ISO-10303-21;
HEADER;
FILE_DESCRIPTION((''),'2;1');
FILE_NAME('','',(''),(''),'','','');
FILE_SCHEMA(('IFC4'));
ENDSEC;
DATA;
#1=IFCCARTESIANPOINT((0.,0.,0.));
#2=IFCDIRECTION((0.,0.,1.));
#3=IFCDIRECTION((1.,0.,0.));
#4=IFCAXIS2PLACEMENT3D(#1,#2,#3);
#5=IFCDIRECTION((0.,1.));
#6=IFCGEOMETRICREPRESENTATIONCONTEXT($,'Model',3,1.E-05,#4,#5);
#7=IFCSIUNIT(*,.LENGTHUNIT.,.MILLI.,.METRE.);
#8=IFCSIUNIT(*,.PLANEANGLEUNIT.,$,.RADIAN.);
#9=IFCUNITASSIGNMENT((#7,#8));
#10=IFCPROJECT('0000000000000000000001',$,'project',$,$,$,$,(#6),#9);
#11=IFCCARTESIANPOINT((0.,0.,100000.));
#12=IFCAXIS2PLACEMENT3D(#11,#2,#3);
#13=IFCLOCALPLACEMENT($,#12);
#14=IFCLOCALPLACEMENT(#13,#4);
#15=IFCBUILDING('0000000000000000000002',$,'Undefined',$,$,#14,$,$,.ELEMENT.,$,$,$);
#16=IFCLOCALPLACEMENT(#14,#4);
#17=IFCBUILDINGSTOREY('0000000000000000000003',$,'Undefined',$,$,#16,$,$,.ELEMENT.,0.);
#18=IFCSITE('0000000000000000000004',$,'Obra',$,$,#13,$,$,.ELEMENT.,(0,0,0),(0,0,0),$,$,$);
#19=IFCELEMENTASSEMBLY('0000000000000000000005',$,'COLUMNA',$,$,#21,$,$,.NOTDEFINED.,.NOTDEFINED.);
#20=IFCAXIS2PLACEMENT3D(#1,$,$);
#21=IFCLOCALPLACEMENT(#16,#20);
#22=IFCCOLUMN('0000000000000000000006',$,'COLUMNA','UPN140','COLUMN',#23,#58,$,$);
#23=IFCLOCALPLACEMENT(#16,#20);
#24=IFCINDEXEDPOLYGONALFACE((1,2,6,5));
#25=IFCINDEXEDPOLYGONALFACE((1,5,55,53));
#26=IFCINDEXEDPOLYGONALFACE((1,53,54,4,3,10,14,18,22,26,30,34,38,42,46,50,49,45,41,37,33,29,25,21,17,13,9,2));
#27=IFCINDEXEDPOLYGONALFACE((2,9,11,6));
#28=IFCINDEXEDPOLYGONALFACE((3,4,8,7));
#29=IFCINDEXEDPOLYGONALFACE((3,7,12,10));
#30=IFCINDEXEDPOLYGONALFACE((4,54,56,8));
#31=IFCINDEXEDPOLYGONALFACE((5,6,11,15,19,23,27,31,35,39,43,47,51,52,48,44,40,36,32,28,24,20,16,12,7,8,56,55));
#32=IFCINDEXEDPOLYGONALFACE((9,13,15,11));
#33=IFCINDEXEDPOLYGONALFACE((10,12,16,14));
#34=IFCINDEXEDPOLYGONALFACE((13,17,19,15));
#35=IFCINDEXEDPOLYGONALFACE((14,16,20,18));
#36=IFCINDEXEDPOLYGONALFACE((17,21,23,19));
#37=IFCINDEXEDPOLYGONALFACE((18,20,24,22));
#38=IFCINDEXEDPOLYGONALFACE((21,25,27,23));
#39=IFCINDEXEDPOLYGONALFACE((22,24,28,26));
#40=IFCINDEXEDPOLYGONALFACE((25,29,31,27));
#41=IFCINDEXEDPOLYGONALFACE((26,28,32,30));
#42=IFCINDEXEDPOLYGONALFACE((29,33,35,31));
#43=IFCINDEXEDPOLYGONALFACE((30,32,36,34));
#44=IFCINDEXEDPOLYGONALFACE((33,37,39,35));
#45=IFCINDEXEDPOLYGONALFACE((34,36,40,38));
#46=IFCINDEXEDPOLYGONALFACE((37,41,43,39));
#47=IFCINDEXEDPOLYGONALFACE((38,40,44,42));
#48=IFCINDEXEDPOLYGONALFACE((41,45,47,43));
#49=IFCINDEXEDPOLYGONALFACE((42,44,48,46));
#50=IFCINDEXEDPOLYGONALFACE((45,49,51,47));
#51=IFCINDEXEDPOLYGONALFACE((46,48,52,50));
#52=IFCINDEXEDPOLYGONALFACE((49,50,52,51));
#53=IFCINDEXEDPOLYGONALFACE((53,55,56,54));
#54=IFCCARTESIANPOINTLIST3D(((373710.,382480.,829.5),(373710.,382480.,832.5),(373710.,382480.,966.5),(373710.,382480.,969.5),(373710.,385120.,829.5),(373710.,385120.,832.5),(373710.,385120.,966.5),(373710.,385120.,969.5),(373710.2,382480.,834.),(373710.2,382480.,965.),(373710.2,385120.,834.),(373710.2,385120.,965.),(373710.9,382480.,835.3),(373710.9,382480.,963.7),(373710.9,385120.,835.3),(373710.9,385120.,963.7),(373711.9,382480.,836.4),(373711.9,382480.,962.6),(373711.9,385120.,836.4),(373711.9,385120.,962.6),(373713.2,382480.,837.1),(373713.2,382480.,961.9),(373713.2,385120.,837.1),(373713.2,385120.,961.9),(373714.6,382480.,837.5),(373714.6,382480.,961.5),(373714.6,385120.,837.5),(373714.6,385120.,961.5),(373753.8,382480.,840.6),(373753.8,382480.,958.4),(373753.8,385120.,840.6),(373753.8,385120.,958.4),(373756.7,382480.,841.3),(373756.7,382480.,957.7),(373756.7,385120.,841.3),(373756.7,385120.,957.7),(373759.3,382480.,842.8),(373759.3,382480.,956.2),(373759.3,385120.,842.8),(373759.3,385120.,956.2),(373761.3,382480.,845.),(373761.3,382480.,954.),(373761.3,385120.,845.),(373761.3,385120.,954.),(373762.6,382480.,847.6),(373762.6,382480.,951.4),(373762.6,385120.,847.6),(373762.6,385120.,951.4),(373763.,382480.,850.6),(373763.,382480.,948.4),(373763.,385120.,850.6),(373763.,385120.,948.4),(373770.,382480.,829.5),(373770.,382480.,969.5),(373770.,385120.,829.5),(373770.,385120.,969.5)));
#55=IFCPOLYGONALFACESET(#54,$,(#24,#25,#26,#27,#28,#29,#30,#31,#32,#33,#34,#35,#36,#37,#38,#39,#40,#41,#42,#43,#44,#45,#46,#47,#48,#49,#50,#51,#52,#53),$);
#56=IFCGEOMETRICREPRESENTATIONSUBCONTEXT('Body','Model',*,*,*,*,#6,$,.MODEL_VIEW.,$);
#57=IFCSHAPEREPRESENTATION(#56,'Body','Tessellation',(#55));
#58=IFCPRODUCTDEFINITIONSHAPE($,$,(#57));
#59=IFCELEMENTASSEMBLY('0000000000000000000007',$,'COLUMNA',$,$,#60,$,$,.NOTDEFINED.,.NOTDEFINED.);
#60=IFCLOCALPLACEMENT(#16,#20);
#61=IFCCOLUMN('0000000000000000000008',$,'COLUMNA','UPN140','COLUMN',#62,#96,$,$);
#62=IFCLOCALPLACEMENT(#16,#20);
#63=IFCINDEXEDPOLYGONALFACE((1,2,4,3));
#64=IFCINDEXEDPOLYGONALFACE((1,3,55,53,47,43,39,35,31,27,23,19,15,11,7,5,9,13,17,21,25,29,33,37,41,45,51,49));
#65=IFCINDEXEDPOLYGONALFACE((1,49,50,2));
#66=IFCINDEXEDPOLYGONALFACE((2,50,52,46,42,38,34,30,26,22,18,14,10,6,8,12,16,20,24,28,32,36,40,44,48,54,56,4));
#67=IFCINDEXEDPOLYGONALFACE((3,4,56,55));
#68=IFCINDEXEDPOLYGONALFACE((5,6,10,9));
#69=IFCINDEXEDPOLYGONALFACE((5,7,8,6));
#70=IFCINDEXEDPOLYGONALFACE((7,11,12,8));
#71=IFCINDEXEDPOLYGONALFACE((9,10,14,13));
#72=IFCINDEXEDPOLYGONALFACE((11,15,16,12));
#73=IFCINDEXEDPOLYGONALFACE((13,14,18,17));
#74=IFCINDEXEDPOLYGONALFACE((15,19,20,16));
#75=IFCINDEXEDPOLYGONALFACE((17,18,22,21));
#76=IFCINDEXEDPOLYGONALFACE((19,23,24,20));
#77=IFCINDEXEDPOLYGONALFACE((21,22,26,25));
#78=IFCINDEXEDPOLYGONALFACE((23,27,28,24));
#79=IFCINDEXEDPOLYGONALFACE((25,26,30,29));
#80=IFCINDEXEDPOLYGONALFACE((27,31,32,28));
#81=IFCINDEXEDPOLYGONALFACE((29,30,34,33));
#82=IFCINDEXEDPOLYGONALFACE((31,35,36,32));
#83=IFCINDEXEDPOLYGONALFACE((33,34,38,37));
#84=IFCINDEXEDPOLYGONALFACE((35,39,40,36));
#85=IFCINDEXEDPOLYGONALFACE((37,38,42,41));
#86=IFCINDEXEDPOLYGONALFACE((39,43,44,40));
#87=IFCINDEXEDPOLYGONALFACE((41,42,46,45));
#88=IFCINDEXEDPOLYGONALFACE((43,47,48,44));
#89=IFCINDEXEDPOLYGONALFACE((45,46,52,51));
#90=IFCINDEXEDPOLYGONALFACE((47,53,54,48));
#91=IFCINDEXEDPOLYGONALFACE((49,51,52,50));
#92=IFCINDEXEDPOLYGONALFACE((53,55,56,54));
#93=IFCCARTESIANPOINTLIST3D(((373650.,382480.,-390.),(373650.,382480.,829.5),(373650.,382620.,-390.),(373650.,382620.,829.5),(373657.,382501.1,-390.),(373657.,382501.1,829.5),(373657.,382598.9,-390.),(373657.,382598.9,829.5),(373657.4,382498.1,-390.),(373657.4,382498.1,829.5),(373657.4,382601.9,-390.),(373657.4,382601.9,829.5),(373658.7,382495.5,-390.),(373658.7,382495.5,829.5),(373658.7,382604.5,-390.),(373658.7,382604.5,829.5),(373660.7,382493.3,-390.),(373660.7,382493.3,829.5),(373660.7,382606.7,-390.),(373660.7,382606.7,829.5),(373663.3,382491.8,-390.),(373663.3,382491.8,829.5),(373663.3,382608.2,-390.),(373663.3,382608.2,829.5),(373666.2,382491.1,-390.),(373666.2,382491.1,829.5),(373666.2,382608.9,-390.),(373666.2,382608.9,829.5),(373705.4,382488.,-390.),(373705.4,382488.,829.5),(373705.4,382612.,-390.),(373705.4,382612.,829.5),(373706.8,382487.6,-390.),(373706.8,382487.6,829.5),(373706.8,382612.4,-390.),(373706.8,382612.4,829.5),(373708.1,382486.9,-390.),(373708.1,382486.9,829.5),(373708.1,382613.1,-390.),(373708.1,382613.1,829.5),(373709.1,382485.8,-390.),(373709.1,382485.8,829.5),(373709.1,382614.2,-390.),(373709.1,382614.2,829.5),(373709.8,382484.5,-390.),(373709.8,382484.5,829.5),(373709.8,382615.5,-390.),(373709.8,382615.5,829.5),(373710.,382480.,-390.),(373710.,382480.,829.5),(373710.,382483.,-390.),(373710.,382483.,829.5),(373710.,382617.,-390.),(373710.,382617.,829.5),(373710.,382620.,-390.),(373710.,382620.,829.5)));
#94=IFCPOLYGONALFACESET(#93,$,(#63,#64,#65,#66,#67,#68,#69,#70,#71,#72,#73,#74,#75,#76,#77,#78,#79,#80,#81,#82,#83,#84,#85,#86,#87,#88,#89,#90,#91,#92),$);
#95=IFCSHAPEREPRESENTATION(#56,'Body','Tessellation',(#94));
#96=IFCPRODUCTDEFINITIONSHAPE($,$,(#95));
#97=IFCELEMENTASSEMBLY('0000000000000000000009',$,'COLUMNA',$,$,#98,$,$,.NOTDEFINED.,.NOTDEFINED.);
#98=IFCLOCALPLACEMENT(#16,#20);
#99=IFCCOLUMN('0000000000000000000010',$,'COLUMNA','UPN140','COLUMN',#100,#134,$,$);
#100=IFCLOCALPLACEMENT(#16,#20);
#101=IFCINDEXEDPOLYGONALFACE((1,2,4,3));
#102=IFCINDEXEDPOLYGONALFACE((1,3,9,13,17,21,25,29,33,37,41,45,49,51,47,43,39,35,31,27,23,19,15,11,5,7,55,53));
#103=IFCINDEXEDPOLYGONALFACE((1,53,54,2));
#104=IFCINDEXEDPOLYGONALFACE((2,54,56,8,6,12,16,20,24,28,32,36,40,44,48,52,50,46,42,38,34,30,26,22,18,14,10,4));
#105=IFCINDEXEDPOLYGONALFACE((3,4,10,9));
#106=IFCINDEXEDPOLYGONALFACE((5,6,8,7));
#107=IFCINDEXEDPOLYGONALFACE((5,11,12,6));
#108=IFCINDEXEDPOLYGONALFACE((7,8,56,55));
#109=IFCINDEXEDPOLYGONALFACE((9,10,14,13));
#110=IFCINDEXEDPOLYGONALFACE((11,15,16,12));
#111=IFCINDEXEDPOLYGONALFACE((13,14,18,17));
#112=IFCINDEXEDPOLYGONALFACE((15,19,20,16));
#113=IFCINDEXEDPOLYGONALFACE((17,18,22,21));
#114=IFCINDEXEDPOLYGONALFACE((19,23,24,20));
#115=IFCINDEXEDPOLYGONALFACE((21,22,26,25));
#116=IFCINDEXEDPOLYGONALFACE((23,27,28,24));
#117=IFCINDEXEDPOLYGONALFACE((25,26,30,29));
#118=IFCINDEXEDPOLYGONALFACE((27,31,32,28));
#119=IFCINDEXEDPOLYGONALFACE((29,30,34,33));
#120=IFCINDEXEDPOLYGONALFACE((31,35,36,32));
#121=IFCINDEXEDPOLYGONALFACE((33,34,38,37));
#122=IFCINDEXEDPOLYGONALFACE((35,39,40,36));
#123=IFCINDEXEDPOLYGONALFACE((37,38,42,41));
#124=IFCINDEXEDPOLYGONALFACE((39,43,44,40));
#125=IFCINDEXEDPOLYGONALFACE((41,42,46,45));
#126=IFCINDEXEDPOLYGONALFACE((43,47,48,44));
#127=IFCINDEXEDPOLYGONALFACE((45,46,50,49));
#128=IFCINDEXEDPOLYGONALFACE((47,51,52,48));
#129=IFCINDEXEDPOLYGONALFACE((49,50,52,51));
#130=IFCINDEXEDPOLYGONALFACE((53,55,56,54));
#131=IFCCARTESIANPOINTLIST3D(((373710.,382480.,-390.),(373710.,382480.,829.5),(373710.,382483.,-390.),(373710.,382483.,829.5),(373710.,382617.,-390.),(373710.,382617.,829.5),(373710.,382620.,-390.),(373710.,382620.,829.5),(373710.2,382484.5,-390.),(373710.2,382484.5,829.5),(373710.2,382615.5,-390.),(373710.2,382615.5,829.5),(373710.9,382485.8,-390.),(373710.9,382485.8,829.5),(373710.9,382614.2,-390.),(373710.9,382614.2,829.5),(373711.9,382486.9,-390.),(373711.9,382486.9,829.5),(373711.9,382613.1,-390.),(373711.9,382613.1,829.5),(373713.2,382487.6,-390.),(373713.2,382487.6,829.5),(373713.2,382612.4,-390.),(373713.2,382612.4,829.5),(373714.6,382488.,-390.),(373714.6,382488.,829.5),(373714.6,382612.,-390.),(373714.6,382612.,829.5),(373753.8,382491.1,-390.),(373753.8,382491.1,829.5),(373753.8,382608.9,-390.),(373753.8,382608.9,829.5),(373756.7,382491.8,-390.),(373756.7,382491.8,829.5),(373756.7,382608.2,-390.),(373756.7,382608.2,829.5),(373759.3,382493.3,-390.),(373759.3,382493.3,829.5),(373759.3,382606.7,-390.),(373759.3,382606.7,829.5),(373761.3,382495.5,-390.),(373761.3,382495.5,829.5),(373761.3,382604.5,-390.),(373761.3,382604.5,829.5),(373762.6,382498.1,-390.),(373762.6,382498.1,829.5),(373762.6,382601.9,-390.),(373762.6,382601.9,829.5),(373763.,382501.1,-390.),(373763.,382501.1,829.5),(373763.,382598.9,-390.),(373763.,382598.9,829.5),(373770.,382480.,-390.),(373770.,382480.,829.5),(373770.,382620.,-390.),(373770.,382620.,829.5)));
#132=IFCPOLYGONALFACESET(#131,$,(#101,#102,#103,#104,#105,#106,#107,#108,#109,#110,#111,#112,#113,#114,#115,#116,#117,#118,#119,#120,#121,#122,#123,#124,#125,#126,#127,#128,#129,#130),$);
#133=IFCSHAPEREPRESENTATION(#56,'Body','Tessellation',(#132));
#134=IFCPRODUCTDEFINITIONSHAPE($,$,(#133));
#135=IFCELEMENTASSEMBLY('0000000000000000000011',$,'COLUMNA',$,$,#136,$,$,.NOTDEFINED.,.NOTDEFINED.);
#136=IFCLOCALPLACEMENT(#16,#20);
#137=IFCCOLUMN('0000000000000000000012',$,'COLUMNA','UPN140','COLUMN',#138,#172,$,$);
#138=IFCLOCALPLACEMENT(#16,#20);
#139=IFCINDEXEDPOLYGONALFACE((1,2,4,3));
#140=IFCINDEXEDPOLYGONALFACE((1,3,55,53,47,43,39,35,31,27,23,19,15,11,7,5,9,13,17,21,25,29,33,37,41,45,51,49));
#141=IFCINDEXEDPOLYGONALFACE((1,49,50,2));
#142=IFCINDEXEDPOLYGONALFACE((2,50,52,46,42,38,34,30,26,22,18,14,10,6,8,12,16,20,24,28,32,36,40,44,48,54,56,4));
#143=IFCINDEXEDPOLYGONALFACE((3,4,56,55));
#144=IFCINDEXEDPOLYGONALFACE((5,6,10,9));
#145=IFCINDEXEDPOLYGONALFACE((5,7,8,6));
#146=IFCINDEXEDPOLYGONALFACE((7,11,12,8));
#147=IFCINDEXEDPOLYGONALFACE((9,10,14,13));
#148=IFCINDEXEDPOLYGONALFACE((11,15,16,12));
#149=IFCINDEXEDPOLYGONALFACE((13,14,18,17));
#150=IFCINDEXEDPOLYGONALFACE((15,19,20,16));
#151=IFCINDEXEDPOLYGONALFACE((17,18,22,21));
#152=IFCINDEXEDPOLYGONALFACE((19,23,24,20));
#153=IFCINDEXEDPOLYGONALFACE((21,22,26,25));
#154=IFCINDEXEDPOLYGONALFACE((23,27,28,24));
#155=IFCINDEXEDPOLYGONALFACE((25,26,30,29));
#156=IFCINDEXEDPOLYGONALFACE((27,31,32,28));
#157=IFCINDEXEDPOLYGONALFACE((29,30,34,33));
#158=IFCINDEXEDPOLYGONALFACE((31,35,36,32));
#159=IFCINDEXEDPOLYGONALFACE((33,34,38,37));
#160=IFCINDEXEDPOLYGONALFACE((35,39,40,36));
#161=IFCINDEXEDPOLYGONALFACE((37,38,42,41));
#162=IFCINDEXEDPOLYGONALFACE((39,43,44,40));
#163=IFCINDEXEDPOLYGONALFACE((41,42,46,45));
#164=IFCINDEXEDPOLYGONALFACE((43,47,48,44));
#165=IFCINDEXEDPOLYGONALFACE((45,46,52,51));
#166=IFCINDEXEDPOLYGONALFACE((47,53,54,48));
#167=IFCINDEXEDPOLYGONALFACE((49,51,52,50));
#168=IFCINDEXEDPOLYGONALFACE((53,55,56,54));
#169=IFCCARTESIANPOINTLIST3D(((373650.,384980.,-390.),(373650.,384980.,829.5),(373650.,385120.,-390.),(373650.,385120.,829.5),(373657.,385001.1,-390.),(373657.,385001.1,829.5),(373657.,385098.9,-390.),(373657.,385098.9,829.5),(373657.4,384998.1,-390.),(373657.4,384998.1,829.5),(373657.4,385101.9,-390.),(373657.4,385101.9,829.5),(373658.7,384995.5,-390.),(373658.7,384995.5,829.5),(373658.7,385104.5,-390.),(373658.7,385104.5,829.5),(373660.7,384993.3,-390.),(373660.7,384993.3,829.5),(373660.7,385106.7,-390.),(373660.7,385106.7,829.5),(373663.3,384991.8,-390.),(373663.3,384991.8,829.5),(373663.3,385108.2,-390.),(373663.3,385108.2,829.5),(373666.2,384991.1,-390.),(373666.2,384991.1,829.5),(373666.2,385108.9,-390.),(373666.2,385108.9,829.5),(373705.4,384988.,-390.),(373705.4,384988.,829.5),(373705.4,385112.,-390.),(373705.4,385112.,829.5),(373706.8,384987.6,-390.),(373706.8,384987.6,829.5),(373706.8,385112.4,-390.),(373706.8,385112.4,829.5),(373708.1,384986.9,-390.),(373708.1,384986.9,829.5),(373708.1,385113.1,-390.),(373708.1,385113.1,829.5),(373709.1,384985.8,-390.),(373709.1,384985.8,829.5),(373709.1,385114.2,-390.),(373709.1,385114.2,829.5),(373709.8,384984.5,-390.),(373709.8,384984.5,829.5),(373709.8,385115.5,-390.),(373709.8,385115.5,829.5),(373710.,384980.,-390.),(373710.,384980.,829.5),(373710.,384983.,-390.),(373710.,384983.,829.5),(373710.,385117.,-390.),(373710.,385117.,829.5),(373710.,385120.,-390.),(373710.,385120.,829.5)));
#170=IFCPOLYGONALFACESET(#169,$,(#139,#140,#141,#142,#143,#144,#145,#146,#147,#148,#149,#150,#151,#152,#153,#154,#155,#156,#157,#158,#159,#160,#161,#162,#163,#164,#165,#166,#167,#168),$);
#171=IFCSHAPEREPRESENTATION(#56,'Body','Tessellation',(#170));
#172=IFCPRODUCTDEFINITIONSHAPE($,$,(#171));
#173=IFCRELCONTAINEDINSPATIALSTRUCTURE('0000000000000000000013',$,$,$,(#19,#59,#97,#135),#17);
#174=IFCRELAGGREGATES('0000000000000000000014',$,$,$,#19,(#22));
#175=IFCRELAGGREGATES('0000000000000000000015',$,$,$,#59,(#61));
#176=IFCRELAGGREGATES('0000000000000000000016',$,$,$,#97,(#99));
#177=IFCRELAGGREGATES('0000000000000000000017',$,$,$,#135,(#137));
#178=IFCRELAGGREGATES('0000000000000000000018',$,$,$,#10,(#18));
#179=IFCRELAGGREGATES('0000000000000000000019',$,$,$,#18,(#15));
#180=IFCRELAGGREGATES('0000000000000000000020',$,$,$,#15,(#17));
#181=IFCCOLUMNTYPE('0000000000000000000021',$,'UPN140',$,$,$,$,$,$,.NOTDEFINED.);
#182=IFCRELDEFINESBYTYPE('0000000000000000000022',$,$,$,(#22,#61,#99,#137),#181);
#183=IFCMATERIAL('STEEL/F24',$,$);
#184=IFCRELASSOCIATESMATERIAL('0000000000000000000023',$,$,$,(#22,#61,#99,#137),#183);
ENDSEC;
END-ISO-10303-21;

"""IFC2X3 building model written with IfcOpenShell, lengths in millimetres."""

from ifc_helpers import new_model, si_unit, direction, frame, origin_with_axes, origin_2d_with_axis, place, context, subcontext, project, spatial, u_section, extrude, material, type_object, element, aggregate, save


model = new_model("IFC2X3")

# Units and contexts
model_context = context("Model", 3, precision=1e-05, world=origin_with_axes(), true_north=direction((0.0, 1.0)))
body_context = subcontext(model_context, "Body", "Model", "MODEL_VIEW")
ifc_project = project(units=[si_unit("LENGTHUNIT", "METRE", prefix="MILLI"), si_unit("PLANEANGLEUNIT", "RADIAN")], contexts=[model_context])

# Site, building, storey
site_placement = place(None, frame((0.0, 0.0, 100000.0), z_axis=(0.0, 0.0, 1.0), x_axis=(1.0, 0.0, 0.0)))
site = spatial("IfcSite", under=ifc_project, at=site_placement, Name="Obra", CompositionType="ELEMENT", RefLatitude=(0, 0, 0), RefLongitude=(0, 0, 0))
building_placement = place(site_placement, origin_with_axes())
building = spatial("IfcBuilding", under=site, at=building_placement, Name="Undefined", CompositionType="ELEMENT")
storey_placement = place(building_placement, origin_with_axes())
storey = spatial("IfcBuildingStorey", under=building, at=storey_placement, Name="Undefined", CompositionType="ELEMENT", Elevation=0.0)

# Element assemblies, columns
ifc_material_1 = material(Name="STEEL/F24")
column_type_1 = type_object("IfcColumnType", Name="UPN140", PredefinedType="NOTDEFINED")
assembly_1_placement = place(storey_placement, origin_with_axes())
assembly_1 = element("IfcElementAssembly", 1, at=assembly_1_placement, inside=storey, Name="COLUMNA", AssemblyPlace="NOTDEFINED", PredefinedType="NOTDEFINED")
column_1_placement = place(assembly_1_placement, frame((373740.0, 385120.0, 899.5), z_axis=(0.0, -1.0, 0.0), x_axis=(0.0, 0.0, 1.0)))
column_1 = element("IfcColumn", 2, at=column_1_placement, type_object=column_type_1, material=ifc_material_1, Name="COLUMNA", Description="UPN140", ObjectType="COLUMN", context=body_context, shape_type="SweptSolid", body=[
    extrude(u_section(Depth=140.0, FlangeWidth=60.0, WebThickness=7.0, FlangeThickness=10.0, FilletRadius=10.0, EdgeRadius=5.0, FlangeSlope=0.07983, at=origin_2d_with_axis()), frame((0.0, 0.0, 2640.0), z_axis=(0.0, 0.0, -1.0), x_axis=(0.0, 1.0, 0.0)), (0.0, 0.0, 1.0), 2640.0),
])
aggregate(assembly_1, [column_1])
assembly_2_placement = place(storey_placement, origin_with_axes())
assembly_2 = element("IfcElementAssembly", 3, at=assembly_2_placement, inside=storey, Name="COLUMNA", AssemblyPlace="NOTDEFINED", PredefinedType="NOTDEFINED")
column_2_placement = place(assembly_2_placement, frame((373680.0, 382550.0, -390.0), z_axis=(0.0, 0.0, 1.0), x_axis=(0.0, -1.0, 0.0)))
column_2 = element("IfcColumn", 4, at=column_2_placement, type_object=column_type_1, material=ifc_material_1, Name="COLUMNA", Description="UPN140", ObjectType="COLUMN", context=body_context, shape_type="SweptSolid", body=[
    extrude(u_section(Depth=140.0, FlangeWidth=60.0, WebThickness=7.0, FlangeThickness=10.0, FilletRadius=10.0, EdgeRadius=5.0, FlangeSlope=0.07983, at=origin_2d_with_axis()), frame((0.0, 0.0, 1219.5), z_axis=(0.0, 0.0, -1.0), x_axis=(0.0, 1.0, 0.0)), (0.0, 0.0, 1.0), 1219.5),
])
aggregate(assembly_2, [column_2])
assembly_3_placement = place(storey_placement, origin_with_axes())
assembly_3 = element("IfcElementAssembly", 5, at=assembly_3_placement, inside=storey, Name="COLUMNA", AssemblyPlace="NOTDEFINED", PredefinedType="NOTDEFINED")
column_3_placement = place(assembly_3_placement, frame((373740.0, 382550.0, -390.0), z_axis=(0.0, 0.0, 1.0), x_axis=(0.0, 1.0, 0.0)))
column_3 = element("IfcColumn", 6, at=column_3_placement, type_object=column_type_1, material=ifc_material_1, Name="COLUMNA", Description="UPN140", ObjectType="COLUMN", context=body_context, shape_type="SweptSolid", body=[
    extrude(u_section(Depth=140.0, FlangeWidth=60.0, WebThickness=7.0, FlangeThickness=10.0, FilletRadius=10.0, EdgeRadius=5.0, FlangeSlope=0.07983, at=origin_2d_with_axis()), frame((0.0, 0.0, 1219.5), z_axis=(0.0, 0.0, -1.0), x_axis=(0.0, 1.0, 0.0)), (0.0, 0.0, 1.0), 1219.5),
])
aggregate(assembly_3, [column_3])
assembly_4_placement = place(storey_placement, origin_with_axes())
assembly_4 = element("IfcElementAssembly", 7, at=assembly_4_placement, inside=storey, Name="COLUMNA", AssemblyPlace="NOTDEFINED", PredefinedType="NOTDEFINED")
column_4_placement = place(assembly_4_placement, frame((373680.0, 385050.0, -390.0), z_axis=(0.0, 0.0, 1.0), x_axis=(0.0, -1.0, 0.0)))
column_4 = element("IfcColumn", 8, at=column_4_placement, type_object=column_type_1, material=ifc_material_1, Name="COLUMNA", Description="UPN140", ObjectType="COLUMN", context=body_context, shape_type="SweptSolid", body=[
    extrude(u_section(Depth=140.0, FlangeWidth=60.0, WebThickness=7.0, FlangeThickness=10.0, FilletRadius=10.0, EdgeRadius=5.0, FlangeSlope=0.07983, at=origin_2d_with_axis()), frame((0.0, 0.0, 1219.5), z_axis=(0.0, 0.0, -1.0), x_axis=(0.0, 1.0, 0.0)), (0.0, 0.0, 1.0), 1219.5),
])
aggregate(assembly_4, [column_4])

save(model, "model.ifc")
